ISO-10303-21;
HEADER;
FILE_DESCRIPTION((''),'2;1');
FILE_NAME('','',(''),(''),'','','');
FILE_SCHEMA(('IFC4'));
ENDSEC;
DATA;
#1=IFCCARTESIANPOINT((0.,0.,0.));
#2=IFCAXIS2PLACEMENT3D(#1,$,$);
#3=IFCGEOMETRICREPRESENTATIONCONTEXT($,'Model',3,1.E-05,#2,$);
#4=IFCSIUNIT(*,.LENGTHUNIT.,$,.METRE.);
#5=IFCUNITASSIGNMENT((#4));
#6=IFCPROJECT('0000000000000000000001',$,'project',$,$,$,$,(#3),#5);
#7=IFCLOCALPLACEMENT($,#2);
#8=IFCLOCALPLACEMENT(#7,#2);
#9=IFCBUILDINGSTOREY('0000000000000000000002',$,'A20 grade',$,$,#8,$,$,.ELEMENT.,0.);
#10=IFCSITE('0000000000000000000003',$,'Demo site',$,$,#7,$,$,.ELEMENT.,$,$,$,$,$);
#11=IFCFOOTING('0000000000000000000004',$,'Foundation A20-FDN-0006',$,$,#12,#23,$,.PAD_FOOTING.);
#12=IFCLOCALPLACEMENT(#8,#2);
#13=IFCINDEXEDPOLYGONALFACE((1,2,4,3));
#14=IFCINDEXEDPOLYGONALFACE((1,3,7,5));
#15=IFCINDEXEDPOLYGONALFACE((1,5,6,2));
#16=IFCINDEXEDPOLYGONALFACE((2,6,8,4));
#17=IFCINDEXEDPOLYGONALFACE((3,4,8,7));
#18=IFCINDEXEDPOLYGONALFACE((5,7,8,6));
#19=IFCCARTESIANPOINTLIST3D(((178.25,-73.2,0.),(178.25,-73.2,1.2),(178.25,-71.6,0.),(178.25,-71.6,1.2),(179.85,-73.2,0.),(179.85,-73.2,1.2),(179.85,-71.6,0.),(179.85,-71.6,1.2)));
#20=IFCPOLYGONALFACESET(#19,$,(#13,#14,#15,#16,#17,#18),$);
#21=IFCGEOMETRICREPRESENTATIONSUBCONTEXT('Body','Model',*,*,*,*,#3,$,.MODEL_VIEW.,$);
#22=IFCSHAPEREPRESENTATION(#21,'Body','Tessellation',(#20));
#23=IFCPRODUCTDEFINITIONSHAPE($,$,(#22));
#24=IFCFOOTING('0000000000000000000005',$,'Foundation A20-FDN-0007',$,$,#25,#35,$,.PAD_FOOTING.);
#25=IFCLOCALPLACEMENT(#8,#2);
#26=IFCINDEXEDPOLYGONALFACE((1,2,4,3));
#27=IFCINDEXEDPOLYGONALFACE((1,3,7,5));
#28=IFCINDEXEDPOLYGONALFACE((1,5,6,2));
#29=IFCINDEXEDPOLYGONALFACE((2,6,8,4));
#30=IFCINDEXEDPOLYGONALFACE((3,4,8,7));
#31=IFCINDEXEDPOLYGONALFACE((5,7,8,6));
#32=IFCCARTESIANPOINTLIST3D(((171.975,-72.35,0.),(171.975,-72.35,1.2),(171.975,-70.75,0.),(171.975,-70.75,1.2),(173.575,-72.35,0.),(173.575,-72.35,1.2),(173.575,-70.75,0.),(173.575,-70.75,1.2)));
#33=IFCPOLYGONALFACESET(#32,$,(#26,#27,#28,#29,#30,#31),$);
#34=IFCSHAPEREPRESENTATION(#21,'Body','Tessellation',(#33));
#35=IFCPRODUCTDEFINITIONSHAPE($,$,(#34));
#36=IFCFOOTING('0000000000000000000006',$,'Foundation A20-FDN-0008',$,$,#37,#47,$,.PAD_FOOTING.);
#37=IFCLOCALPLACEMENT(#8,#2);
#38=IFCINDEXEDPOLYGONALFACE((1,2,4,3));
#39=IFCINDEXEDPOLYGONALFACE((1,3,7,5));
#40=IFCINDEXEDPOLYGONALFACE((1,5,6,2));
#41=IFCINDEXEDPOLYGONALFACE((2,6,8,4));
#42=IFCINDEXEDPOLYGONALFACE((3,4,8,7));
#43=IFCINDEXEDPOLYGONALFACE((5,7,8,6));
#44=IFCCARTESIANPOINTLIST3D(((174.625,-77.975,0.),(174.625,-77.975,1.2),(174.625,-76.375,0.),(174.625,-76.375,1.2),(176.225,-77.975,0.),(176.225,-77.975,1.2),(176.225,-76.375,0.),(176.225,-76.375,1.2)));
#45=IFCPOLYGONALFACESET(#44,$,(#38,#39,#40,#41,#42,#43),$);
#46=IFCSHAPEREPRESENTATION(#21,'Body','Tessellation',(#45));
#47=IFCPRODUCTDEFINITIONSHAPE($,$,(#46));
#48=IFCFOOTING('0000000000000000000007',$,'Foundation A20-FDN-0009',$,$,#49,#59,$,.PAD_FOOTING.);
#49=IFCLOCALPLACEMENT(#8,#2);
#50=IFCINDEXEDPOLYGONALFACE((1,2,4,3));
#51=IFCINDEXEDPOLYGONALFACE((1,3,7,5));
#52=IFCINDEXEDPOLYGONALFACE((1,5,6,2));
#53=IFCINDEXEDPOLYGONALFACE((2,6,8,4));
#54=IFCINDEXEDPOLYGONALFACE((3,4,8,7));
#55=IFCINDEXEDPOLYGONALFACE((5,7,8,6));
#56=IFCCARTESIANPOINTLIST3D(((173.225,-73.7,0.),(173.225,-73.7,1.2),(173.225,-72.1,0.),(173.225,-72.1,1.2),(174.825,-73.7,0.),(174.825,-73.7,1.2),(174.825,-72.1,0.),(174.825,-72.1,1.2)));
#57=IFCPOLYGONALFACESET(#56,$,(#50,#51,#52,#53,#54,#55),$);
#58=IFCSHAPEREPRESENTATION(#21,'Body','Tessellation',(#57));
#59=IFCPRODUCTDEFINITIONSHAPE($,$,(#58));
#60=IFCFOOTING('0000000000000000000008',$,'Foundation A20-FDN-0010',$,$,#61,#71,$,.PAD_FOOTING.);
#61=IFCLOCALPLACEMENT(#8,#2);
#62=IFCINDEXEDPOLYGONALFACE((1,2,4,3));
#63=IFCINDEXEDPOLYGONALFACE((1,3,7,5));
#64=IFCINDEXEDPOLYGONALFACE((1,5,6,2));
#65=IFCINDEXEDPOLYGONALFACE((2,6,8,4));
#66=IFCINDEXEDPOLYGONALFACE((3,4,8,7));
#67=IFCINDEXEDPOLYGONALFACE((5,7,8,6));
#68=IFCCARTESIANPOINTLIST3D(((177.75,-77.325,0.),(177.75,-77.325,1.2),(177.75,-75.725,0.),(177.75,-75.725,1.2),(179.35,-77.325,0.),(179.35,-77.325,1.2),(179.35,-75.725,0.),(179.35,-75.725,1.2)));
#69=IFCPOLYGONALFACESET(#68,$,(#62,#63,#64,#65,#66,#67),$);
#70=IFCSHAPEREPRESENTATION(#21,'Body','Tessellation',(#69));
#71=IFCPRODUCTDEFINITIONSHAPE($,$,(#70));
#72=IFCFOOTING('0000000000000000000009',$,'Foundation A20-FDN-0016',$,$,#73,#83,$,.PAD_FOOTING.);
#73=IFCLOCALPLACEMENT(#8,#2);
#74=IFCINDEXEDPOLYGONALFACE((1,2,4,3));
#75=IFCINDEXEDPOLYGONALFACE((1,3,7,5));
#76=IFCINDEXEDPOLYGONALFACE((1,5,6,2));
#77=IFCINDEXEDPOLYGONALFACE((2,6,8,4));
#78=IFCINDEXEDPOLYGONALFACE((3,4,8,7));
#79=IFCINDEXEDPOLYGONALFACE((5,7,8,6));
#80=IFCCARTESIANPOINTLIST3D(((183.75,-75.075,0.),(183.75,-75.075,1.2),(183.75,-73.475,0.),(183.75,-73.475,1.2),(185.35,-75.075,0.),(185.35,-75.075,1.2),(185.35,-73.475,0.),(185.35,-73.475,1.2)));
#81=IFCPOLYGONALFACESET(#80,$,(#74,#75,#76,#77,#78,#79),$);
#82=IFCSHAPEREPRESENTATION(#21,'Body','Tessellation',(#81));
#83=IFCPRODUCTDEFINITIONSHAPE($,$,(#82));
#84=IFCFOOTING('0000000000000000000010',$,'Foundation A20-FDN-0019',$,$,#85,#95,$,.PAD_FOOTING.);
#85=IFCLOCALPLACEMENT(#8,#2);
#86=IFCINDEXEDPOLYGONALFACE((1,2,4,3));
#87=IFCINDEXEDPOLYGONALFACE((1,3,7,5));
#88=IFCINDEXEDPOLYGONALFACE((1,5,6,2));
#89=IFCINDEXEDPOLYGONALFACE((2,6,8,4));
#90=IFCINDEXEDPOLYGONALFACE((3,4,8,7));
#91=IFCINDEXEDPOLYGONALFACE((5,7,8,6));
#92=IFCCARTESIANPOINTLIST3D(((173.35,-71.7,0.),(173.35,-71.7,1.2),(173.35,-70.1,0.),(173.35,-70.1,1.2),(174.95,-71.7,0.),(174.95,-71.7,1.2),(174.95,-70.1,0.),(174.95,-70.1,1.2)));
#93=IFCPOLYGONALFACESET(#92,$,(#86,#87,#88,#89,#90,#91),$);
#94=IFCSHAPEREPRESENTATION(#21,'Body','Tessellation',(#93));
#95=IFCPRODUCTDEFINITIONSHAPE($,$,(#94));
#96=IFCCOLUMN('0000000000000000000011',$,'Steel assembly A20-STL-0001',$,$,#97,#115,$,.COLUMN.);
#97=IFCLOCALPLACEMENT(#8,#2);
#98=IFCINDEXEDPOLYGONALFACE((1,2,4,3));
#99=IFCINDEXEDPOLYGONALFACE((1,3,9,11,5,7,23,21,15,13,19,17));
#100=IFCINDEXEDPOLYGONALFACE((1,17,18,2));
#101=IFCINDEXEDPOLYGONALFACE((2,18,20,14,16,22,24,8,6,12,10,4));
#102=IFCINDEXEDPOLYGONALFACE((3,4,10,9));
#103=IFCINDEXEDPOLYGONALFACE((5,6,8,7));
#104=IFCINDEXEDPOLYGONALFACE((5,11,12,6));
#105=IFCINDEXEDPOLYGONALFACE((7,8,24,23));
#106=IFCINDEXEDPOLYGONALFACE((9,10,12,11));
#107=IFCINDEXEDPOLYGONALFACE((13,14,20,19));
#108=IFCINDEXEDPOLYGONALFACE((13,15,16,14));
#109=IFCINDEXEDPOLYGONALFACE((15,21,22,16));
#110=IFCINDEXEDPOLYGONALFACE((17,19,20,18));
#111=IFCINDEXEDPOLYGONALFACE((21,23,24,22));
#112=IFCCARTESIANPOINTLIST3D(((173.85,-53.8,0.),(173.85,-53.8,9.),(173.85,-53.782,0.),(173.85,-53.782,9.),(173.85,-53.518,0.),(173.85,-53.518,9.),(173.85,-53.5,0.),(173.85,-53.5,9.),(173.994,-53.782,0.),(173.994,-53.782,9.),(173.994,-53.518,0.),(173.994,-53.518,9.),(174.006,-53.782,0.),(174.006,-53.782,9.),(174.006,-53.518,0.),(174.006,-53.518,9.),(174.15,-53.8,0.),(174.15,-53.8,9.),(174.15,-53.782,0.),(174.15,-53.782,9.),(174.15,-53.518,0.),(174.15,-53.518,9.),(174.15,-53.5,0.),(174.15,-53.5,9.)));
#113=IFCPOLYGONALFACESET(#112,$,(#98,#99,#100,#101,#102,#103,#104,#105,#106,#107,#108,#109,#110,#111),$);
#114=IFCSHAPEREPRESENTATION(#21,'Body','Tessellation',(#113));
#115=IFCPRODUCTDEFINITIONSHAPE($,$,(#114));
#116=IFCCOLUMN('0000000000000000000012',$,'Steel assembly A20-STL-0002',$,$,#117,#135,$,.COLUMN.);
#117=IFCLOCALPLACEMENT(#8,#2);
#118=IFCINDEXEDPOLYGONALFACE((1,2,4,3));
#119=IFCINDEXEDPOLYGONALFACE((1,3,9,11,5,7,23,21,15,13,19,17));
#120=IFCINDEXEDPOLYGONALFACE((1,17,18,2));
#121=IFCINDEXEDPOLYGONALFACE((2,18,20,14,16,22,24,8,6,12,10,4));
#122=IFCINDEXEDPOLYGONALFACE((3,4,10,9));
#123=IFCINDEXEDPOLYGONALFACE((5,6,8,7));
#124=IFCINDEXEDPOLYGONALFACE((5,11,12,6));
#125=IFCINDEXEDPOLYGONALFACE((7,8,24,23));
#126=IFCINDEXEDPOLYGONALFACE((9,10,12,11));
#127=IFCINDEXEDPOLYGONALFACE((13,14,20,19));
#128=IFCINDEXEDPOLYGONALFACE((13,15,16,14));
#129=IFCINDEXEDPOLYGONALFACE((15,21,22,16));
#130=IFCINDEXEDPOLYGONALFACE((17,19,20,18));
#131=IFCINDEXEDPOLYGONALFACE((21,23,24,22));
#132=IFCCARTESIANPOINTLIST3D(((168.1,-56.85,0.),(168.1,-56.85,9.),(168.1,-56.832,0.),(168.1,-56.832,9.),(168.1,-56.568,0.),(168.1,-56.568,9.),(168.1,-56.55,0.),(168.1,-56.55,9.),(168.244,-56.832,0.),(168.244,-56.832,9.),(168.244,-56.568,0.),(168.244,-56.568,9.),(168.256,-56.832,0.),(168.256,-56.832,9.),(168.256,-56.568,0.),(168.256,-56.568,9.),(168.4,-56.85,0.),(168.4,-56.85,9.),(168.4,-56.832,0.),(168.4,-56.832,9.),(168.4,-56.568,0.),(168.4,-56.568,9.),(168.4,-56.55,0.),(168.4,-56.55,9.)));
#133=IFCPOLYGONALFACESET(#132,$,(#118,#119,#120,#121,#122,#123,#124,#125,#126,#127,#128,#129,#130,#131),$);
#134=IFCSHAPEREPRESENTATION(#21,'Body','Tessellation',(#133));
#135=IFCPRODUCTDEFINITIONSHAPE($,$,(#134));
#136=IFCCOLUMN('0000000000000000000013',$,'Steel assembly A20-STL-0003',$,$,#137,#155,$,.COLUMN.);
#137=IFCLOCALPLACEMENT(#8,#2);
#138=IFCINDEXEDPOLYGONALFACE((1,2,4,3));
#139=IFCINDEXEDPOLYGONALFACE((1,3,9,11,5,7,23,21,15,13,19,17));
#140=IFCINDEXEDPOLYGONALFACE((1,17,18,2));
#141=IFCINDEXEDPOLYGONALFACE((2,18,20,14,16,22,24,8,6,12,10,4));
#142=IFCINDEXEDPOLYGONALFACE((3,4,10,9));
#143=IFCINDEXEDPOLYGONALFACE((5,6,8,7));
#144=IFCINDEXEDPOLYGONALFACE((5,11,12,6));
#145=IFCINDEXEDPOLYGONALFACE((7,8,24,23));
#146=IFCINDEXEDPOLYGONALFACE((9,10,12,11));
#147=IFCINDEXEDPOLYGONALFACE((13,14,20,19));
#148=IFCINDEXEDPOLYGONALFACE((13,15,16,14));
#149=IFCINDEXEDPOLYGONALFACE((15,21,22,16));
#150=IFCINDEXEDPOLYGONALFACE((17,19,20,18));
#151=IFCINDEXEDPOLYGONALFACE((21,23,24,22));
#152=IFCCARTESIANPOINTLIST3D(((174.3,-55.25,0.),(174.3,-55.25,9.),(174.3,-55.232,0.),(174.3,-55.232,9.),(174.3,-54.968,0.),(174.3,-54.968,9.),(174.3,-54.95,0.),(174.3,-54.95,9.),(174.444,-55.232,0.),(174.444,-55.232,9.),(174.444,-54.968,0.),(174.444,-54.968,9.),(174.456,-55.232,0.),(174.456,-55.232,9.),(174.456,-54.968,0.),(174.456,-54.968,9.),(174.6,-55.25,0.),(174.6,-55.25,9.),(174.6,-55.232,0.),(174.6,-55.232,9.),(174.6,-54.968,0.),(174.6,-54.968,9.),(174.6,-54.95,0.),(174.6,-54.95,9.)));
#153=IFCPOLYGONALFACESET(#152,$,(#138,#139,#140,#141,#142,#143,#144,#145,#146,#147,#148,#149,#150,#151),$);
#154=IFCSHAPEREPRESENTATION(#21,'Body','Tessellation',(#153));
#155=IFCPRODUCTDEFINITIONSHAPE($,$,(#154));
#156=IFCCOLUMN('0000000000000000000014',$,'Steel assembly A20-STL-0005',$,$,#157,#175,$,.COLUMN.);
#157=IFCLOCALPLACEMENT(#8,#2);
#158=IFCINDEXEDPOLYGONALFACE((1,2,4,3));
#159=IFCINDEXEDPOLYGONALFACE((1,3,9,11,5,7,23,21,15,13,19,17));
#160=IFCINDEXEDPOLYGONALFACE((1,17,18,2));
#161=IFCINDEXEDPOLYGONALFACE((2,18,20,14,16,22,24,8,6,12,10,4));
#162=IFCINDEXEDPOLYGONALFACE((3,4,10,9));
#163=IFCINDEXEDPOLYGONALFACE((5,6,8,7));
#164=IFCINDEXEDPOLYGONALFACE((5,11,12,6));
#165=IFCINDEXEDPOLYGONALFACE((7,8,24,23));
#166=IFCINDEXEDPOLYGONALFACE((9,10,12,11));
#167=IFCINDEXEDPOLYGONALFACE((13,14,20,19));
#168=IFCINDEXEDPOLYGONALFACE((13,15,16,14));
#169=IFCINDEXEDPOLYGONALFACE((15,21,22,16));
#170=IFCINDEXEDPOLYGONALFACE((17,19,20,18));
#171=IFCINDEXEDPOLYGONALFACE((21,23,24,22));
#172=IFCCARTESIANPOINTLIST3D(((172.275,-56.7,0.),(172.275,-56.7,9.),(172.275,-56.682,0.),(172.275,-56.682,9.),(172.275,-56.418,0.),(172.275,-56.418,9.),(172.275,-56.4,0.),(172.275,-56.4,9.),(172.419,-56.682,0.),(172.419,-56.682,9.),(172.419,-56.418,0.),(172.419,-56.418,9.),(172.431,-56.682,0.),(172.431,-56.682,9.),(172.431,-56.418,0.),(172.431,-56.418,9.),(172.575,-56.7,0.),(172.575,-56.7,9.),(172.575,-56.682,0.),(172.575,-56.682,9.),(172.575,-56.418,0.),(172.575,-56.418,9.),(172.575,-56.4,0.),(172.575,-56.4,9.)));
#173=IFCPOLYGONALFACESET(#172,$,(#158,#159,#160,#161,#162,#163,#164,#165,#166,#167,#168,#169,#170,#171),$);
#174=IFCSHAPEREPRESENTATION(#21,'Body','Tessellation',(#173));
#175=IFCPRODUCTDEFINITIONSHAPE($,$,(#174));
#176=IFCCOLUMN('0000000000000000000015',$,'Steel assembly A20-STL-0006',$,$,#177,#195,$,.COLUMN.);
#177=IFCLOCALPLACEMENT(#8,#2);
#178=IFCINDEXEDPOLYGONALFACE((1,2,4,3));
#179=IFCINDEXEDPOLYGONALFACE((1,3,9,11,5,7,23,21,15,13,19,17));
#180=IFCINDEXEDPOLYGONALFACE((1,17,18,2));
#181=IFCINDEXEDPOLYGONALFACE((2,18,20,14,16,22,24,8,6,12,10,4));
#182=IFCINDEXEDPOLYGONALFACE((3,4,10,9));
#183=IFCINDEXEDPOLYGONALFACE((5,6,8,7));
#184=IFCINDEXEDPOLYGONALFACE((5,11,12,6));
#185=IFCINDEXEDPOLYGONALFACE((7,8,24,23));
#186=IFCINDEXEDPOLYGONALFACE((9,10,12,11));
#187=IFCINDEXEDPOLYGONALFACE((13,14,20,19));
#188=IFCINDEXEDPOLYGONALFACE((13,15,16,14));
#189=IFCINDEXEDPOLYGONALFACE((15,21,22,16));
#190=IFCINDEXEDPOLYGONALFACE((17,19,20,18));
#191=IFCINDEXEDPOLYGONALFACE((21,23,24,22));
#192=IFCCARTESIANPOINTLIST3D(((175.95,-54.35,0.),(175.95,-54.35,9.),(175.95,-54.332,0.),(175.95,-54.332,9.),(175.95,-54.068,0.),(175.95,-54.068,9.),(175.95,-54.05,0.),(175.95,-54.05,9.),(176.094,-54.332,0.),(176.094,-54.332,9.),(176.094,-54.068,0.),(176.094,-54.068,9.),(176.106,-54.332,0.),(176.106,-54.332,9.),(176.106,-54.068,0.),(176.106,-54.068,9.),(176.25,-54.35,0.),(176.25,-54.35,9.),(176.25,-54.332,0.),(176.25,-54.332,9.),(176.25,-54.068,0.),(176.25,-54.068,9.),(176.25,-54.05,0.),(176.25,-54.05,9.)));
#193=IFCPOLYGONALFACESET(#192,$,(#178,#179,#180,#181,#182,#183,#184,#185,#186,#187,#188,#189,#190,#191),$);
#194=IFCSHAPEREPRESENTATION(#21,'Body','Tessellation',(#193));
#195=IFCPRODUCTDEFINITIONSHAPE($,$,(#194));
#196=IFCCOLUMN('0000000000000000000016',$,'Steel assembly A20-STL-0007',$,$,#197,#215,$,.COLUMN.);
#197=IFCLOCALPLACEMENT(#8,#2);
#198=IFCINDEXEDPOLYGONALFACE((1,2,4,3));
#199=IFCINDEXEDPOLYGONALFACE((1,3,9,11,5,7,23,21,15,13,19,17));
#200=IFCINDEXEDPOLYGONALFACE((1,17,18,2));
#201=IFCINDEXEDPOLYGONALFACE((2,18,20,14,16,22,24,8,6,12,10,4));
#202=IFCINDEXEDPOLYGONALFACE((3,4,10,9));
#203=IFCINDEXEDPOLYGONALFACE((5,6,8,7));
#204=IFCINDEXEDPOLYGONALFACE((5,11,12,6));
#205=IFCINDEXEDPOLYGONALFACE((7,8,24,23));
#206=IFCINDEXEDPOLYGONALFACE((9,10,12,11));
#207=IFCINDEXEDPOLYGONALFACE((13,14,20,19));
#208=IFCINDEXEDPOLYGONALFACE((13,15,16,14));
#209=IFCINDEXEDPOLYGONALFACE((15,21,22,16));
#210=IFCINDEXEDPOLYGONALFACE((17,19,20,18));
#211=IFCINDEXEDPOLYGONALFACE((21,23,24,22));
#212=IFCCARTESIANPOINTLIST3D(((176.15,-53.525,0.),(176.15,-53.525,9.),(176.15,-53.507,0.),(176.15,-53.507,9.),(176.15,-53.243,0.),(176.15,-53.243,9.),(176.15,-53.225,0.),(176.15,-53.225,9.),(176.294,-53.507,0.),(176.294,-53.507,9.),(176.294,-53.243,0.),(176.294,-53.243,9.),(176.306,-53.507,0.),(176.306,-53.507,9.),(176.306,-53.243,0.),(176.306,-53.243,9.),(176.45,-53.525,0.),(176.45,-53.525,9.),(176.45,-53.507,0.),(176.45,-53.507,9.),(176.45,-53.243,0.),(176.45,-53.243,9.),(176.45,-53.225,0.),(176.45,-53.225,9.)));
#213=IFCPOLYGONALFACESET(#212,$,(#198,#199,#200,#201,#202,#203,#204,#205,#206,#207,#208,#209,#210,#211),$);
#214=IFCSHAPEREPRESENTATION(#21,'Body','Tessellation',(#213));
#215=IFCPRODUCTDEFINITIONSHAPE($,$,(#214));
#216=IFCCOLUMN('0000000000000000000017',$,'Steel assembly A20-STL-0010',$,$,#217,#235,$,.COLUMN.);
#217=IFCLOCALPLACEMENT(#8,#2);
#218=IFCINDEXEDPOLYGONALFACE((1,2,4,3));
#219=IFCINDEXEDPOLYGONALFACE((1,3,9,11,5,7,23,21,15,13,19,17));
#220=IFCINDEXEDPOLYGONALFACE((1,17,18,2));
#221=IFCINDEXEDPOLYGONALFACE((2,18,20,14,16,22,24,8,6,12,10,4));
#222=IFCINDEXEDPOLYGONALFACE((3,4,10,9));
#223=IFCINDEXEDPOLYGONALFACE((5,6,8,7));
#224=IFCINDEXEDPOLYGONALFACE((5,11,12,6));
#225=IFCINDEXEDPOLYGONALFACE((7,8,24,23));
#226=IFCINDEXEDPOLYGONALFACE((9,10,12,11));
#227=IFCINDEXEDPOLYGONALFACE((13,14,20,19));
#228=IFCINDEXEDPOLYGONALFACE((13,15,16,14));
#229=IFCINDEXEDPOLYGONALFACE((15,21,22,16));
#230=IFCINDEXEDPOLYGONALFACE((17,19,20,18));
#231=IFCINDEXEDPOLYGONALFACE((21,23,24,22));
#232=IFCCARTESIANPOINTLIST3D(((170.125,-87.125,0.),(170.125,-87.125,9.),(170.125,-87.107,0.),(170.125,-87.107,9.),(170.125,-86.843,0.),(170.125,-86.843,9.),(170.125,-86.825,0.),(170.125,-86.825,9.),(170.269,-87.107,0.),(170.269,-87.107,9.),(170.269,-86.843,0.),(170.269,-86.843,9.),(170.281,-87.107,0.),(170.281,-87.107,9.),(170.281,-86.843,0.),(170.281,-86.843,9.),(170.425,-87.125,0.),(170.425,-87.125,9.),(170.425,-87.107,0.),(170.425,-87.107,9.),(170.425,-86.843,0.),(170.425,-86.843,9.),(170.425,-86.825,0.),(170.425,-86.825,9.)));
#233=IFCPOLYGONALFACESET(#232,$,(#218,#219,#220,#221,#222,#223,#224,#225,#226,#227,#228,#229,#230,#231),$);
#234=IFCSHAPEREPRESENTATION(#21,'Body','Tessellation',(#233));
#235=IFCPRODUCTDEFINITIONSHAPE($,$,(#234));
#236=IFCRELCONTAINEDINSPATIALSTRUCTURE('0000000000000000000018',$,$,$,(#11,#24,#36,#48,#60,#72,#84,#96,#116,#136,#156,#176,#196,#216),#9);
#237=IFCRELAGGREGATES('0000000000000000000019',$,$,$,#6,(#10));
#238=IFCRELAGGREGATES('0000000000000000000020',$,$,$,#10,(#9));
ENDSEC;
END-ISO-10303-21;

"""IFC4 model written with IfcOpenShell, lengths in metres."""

from ifc_helpers import new_model, si_unit, frame, origin, place, context, subcontext, project, spatial, rectangle, i_section, extrude, element, save


model = new_model("IFC4")

# Units and contexts
model_context = context("Model", 3, precision=1e-05, world=origin())
body_context = subcontext(model_context, "Body", "Model", "MODEL_VIEW")
ifc_project = project(units=[si_unit("LENGTHUNIT", "METRE")], contexts=[model_context])

# Site, storey
site_placement = place(None, origin())
site = spatial("IfcSite", under=ifc_project, at=site_placement, Name="Demo site", CompositionType="ELEMENT")
storey_placement = place(site_placement, origin())
storey = spatial("IfcBuildingStorey", under=site, at=storey_placement, Name="A20 grade", CompositionType="ELEMENT", Elevation=0.0)

# Footings
for number, where, name in (
    (1, (179.05, -72.4, 0.0), "Foundation A20-FDN-0006"),
    (2, (172.775, -71.55, 0.0), "Foundation A20-FDN-0007"),
    (3, (175.425, -77.175, 0.0), "Foundation A20-FDN-0008"),
    (4, (174.025, -72.9, 0.0), "Foundation A20-FDN-0009"),
    (5, (178.55, -76.525, 0.0), "Foundation A20-FDN-0010"),
    (6, (184.55, -74.275, 0.0), "Foundation A20-FDN-0016"),
    (7, (174.15, -70.9, 0.0), "Foundation A20-FDN-0019"),
):
    element("IfcFooting", number, at=place(storey_placement, frame(where)), inside=storey, Name=name, PredefinedType="PAD_FOOTING", context=body_context, shape_type="SweptSolid", body=[
        extrude(rectangle(XDim=1.6, YDim=1.6), origin(), (0.0, 0.0, 1.0), 1.2),
    ])

# Columns
for number, where, name in (
    (8, (174.0, -53.65, 0.0), "Steel assembly A20-STL-0001"),
    (9, (168.25, -56.7, 0.0), "Steel assembly A20-STL-0002"),
    (10, (174.45, -55.1, 0.0), "Steel assembly A20-STL-0003"),
    (11, (172.425, -56.55, 0.0), "Steel assembly A20-STL-0005"),
    (12, (176.1, -54.2, 0.0), "Steel assembly A20-STL-0006"),
    (13, (176.3, -53.375, 0.0), "Steel assembly A20-STL-0007"),
    (14, (170.275, -86.975, 0.0), "Steel assembly A20-STL-0010"),
):
    element("IfcColumn", number, at=place(storey_placement, frame(where)), inside=storey, Name=name, PredefinedType="COLUMN", context=body_context, shape_type="SweptSolid", body=[
        extrude(i_section(OverallWidth=0.3, OverallDepth=0.3, WebThickness=0.012, FlangeThickness=0.018), origin(), (0.0, 0.0, 1.0), 9.0),
    ])

save(model, "model.ifc")
